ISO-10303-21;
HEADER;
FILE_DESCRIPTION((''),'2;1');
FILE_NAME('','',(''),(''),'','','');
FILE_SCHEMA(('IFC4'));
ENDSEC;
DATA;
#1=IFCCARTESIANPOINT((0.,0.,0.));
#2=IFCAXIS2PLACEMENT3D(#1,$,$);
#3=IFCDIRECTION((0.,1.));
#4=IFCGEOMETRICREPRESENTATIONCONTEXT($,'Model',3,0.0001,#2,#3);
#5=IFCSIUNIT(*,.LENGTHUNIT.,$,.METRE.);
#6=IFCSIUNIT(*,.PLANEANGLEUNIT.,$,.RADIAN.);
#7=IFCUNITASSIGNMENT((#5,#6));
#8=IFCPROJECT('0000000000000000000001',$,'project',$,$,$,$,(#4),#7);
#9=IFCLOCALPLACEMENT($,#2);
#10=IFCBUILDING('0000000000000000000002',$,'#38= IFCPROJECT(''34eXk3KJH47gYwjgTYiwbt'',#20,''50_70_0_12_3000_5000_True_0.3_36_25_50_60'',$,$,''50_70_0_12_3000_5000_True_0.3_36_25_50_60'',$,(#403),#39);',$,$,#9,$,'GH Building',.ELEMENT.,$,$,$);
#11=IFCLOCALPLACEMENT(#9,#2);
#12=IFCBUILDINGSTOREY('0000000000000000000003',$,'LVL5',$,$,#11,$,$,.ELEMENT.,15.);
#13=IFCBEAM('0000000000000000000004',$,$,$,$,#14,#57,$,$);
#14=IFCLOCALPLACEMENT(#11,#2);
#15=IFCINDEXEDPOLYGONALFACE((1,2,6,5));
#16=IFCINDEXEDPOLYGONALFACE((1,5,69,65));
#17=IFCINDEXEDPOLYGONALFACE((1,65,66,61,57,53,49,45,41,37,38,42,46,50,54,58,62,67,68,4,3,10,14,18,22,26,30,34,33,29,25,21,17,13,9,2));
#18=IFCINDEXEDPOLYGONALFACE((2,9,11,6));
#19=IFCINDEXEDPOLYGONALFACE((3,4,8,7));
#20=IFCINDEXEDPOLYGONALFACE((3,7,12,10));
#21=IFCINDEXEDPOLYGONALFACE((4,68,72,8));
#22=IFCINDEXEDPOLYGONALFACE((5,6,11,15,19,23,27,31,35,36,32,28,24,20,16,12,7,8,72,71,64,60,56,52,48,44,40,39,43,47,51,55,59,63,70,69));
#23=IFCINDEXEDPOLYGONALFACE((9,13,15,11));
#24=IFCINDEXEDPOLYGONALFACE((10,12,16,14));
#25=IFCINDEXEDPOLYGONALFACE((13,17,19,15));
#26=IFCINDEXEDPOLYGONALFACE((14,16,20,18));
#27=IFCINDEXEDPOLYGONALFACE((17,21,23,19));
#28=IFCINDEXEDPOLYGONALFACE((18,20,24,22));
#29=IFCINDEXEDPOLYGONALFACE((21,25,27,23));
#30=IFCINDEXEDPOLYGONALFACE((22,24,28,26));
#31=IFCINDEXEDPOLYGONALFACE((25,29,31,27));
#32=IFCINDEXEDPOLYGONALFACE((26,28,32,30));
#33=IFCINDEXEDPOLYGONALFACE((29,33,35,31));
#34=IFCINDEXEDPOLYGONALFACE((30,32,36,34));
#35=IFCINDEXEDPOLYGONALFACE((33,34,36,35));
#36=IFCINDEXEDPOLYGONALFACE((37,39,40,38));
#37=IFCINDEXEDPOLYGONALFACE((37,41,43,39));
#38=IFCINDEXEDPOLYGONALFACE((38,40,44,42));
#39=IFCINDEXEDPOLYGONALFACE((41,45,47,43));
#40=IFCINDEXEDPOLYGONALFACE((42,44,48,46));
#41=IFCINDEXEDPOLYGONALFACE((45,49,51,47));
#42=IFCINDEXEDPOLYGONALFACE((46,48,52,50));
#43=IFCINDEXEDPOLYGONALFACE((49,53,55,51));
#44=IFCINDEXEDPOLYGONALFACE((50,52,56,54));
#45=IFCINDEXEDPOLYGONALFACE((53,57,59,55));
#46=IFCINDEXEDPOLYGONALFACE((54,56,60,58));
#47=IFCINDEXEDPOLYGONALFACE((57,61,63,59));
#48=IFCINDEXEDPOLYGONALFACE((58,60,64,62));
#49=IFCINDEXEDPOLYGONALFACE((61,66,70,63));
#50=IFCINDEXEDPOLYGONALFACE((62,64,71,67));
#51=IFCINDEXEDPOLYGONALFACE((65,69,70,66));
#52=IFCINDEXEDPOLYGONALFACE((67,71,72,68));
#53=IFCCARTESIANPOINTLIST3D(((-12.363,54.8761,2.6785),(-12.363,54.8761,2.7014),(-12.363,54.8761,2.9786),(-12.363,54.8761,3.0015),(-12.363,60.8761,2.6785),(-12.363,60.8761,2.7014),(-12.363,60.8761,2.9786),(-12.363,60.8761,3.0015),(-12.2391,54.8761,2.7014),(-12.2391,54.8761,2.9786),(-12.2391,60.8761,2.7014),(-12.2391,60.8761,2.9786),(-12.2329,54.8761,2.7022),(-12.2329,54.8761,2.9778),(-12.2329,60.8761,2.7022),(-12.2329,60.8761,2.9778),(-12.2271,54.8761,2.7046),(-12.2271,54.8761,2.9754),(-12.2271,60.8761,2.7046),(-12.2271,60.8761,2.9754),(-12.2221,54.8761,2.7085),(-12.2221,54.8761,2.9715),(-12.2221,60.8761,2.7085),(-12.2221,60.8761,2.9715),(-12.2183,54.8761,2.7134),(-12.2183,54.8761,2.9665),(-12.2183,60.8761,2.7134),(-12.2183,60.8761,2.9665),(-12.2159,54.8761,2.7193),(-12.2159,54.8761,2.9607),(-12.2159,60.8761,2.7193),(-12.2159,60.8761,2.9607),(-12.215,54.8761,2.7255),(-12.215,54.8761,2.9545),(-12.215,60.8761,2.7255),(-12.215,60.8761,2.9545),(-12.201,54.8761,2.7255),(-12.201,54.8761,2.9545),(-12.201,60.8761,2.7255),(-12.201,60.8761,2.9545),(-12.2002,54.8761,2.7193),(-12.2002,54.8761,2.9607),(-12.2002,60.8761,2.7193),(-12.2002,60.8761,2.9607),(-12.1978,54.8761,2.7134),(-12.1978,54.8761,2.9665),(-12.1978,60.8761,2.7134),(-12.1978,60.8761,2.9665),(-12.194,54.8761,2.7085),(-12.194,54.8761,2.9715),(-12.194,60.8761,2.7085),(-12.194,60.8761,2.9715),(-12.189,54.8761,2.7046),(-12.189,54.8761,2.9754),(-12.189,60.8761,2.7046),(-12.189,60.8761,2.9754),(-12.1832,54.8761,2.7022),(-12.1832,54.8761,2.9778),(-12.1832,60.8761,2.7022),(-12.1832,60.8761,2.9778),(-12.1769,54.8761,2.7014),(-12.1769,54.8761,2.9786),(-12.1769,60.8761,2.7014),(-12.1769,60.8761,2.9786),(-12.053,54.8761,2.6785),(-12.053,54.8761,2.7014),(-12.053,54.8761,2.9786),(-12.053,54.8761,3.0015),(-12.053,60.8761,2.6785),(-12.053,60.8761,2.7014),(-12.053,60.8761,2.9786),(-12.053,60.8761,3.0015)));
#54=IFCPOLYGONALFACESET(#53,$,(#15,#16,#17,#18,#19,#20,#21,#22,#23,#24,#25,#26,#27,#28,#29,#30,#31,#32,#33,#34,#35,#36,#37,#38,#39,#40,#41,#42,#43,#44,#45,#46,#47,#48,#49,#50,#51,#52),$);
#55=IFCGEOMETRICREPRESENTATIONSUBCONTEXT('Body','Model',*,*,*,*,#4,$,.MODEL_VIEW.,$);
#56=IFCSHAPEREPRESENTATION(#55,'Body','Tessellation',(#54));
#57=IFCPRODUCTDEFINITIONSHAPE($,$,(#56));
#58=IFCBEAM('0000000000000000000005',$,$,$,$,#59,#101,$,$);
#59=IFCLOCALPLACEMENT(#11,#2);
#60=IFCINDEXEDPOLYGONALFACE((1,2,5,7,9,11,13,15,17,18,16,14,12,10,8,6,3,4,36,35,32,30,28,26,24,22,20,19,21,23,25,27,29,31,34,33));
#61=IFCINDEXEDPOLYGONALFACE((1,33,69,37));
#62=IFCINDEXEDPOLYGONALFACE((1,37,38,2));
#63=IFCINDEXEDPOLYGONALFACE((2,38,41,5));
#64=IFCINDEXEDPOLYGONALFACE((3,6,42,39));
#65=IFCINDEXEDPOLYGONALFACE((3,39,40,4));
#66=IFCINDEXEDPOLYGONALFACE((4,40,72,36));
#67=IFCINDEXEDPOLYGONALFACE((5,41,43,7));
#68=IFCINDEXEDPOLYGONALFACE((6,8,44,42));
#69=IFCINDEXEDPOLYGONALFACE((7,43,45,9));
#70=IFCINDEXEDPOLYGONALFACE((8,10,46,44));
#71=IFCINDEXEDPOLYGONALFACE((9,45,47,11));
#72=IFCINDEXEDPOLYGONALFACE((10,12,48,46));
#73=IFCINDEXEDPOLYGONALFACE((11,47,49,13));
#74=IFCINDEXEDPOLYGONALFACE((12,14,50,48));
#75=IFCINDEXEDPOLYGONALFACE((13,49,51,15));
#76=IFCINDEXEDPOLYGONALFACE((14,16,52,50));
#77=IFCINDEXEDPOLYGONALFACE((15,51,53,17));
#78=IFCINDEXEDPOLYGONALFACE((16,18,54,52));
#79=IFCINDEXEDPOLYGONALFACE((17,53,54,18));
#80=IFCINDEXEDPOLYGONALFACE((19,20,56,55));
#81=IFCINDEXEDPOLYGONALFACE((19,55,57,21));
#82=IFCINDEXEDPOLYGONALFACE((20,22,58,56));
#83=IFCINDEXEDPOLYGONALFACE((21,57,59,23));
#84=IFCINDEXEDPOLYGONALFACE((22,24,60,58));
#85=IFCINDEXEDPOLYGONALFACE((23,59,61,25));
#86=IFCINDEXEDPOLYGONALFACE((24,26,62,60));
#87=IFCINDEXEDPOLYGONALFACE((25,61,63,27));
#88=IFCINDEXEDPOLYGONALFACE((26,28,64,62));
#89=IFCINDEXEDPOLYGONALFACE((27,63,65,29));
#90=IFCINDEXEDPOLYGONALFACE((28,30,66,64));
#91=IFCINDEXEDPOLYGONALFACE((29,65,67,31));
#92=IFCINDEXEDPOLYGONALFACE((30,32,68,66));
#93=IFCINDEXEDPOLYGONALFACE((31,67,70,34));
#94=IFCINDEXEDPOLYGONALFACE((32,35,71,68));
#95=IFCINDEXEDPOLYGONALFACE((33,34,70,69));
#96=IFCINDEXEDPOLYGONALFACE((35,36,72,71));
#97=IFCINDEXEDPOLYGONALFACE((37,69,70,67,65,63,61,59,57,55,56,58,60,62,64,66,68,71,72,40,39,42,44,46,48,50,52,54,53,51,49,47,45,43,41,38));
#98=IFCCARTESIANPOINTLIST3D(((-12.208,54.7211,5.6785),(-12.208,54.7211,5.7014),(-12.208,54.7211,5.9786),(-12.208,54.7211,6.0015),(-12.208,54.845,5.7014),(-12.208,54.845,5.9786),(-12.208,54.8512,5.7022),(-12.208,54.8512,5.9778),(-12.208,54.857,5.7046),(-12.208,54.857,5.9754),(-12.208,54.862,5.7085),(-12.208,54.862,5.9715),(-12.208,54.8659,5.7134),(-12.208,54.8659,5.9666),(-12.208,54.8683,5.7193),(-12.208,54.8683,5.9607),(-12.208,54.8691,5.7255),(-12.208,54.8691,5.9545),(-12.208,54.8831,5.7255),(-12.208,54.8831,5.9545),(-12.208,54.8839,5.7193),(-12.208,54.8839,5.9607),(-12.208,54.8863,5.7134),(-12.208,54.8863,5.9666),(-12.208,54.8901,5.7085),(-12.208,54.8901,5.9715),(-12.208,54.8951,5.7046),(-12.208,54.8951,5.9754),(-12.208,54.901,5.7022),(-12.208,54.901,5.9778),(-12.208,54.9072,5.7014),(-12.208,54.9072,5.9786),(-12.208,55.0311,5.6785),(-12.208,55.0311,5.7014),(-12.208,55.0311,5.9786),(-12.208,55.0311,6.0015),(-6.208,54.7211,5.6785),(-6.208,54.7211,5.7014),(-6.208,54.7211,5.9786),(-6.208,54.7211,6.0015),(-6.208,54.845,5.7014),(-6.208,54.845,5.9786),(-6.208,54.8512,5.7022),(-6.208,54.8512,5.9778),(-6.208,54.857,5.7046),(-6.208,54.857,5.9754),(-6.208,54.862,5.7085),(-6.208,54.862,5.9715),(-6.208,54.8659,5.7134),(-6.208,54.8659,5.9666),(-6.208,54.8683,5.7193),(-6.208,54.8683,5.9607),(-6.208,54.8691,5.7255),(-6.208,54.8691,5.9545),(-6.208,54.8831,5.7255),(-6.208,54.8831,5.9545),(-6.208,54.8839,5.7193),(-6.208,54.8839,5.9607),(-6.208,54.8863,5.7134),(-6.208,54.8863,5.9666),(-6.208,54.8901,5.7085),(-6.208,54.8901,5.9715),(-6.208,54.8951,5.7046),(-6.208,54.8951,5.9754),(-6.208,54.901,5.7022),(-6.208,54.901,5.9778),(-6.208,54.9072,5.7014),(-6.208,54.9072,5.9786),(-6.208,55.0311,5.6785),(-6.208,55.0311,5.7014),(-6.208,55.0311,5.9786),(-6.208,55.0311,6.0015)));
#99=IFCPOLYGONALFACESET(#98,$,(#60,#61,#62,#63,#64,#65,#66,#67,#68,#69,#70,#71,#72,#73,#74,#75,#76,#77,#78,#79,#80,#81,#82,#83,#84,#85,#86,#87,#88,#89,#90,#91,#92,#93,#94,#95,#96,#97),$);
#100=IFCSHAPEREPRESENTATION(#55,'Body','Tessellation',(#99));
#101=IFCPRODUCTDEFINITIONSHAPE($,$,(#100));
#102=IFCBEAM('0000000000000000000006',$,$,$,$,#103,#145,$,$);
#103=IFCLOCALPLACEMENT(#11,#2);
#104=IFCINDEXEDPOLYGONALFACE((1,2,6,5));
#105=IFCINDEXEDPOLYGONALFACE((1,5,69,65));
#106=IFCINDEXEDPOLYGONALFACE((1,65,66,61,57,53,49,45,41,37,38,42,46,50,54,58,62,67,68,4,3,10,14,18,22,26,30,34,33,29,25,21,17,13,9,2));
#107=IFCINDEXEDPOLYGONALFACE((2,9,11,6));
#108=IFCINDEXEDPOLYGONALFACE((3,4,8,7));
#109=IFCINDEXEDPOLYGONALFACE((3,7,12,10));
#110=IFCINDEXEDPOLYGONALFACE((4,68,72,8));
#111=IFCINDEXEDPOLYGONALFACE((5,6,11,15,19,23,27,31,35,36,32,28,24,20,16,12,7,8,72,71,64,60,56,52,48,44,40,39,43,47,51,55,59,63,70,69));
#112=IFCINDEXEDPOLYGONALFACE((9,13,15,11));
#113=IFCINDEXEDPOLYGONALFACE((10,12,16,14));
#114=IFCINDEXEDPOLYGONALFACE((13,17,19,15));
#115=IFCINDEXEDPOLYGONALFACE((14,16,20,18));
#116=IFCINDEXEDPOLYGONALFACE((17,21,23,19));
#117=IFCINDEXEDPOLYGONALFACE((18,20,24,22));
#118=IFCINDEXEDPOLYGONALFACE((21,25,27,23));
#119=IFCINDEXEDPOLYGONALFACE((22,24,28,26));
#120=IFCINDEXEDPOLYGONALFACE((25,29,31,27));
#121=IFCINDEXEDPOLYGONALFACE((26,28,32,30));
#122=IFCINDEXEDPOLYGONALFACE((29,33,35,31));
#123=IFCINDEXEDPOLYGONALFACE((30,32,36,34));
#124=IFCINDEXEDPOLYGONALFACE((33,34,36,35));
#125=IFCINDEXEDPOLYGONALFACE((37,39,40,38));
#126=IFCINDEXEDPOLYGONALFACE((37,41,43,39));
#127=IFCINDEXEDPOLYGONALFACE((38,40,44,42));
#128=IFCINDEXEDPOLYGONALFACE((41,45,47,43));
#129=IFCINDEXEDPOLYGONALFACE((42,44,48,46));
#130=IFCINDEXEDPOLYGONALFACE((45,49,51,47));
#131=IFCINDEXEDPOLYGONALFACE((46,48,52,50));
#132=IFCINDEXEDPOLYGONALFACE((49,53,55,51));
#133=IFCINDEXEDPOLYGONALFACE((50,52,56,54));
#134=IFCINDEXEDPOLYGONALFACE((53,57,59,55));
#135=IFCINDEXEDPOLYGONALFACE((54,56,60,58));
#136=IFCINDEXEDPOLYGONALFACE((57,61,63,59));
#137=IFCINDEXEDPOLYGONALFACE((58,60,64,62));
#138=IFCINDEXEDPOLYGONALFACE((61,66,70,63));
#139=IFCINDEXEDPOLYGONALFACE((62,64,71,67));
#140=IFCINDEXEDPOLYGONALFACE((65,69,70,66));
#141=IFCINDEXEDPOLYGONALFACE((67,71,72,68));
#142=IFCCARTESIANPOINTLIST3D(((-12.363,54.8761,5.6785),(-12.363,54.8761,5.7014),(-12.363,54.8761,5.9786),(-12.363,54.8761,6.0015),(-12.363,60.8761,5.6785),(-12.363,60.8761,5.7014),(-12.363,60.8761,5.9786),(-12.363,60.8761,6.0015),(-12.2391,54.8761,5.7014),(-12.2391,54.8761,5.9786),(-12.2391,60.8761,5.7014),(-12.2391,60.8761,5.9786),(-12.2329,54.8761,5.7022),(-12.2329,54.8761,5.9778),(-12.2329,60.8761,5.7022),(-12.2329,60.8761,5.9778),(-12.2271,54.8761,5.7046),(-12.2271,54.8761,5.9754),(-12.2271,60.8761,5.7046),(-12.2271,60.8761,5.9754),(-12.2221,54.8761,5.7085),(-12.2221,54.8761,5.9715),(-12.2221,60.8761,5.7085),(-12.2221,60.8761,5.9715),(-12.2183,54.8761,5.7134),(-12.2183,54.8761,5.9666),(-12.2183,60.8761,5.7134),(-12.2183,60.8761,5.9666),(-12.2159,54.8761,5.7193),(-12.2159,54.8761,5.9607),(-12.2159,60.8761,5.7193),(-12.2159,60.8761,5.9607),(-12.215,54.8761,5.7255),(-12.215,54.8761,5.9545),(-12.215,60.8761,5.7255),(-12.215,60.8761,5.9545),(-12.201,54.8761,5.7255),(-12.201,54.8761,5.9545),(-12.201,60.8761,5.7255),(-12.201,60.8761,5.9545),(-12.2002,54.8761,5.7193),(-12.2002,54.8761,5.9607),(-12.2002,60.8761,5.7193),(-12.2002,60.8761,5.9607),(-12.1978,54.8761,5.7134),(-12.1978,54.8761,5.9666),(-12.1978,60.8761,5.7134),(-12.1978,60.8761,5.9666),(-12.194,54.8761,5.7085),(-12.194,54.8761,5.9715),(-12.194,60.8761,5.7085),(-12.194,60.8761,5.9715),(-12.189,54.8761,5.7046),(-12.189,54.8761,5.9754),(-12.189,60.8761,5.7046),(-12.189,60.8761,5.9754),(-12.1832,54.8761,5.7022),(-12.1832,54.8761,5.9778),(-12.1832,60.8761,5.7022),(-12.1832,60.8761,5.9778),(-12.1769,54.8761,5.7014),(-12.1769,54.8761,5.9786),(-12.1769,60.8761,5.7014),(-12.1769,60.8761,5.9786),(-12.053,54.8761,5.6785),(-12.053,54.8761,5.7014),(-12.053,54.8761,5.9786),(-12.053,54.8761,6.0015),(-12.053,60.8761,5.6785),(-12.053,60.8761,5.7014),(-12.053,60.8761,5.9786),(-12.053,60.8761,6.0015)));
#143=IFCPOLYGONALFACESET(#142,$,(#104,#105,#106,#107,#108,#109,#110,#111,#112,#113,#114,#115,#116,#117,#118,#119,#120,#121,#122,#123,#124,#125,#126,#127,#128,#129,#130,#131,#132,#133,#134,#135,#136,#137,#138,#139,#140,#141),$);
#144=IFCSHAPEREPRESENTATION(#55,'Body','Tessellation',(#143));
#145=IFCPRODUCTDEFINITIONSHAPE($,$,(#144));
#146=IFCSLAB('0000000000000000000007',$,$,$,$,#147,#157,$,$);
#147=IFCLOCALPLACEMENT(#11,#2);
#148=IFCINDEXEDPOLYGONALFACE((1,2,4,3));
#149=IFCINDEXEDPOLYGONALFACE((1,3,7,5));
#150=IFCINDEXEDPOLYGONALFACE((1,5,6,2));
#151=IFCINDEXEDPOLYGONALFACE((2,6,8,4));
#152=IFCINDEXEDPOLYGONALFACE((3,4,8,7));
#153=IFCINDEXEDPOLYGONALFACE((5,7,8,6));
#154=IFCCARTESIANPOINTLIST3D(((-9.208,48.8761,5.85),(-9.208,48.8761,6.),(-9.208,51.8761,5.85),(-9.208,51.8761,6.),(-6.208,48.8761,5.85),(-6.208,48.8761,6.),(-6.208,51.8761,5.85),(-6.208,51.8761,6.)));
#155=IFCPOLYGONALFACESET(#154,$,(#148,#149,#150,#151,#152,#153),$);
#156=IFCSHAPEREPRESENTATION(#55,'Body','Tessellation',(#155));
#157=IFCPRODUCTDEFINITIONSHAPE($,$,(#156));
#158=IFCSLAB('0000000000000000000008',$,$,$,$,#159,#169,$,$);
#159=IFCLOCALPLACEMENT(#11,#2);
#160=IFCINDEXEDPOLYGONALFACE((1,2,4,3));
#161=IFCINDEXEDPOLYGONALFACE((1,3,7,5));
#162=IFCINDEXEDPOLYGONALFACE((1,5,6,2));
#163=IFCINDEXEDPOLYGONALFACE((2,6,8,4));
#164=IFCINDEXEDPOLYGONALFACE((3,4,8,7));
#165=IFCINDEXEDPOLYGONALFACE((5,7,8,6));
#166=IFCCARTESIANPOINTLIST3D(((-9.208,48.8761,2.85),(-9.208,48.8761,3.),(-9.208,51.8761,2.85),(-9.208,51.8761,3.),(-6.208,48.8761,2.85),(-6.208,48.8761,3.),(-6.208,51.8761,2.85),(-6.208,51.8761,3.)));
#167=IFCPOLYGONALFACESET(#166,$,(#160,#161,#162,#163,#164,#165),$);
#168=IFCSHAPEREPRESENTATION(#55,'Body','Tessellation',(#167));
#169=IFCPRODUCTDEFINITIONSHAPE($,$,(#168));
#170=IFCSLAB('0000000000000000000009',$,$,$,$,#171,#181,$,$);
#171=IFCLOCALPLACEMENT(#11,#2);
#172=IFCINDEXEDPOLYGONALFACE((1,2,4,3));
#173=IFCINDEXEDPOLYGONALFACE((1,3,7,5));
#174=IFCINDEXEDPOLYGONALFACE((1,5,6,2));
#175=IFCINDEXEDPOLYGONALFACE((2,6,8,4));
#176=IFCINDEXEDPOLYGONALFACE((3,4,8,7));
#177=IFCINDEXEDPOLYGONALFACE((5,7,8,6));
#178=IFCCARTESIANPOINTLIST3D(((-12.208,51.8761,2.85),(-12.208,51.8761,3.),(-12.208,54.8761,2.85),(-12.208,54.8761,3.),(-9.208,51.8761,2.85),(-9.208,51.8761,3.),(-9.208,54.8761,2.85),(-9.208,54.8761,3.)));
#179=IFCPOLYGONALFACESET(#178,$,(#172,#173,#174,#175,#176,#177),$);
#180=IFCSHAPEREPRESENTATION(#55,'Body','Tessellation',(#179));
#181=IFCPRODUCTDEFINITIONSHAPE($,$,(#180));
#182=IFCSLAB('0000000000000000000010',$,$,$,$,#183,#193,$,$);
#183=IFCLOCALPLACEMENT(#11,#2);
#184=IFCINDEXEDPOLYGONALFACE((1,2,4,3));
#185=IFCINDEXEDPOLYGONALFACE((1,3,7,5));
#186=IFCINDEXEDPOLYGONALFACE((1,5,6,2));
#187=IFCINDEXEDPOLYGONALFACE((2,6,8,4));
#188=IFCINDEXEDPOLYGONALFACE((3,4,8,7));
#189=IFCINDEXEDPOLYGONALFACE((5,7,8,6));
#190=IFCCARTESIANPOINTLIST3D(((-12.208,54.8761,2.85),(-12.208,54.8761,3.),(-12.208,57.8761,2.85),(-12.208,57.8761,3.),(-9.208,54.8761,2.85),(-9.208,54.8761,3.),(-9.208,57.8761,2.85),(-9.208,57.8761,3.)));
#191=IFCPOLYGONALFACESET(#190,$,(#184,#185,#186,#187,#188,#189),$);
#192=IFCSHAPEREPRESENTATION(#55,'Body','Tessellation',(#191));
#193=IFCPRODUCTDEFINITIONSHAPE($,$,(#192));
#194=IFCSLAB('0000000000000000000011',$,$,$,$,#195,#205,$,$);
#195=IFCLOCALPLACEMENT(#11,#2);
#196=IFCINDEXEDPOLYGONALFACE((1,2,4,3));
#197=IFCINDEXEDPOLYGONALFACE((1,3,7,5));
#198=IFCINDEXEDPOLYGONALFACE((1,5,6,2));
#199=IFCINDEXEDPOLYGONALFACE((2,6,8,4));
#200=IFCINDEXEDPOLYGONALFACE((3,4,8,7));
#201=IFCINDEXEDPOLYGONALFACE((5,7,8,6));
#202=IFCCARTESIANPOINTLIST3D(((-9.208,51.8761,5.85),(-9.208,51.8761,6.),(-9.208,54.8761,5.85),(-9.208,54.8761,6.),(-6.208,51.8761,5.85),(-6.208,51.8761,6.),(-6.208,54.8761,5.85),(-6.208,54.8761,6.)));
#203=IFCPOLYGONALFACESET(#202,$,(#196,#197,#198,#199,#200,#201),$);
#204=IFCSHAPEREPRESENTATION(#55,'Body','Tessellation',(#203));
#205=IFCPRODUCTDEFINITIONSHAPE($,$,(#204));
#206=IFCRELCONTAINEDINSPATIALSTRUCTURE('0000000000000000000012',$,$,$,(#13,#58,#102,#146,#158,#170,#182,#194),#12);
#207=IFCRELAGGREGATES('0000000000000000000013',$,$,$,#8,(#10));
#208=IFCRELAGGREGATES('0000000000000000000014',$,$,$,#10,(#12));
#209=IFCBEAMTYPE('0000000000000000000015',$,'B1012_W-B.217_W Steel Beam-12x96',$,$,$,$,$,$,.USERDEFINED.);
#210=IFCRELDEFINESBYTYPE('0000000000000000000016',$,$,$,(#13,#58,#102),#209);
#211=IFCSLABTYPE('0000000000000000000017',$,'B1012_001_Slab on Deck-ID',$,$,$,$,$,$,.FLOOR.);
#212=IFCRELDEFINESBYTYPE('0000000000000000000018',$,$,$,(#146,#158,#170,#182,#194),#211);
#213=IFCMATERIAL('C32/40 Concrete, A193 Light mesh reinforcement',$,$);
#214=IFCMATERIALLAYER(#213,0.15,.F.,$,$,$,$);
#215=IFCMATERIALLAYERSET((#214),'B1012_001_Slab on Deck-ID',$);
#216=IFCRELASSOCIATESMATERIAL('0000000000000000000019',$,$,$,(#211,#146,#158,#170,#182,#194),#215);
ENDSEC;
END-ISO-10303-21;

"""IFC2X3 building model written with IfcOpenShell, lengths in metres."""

from ifc_helpers import new_model, si_unit, direction, frame, origin, origin_2d, place, context, subcontext, project, spatial, polyline, i_section, outline, extrude, material, layer, layer_set, layer_usage, type_object, element, save


model = new_model("IFC2X3")

# Units and contexts
model_context = context("Model", 3, precision=0.0001, world=origin(), true_north=direction((0.0, 1.0)))
body_context = subcontext(model_context, "Body", "Model", "MODEL_VIEW")
ifc_project = project(units=[si_unit("LENGTHUNIT", "METRE"), si_unit("PLANEANGLEUNIT", "RADIAN")], contexts=[model_context])

# Building, storey
building_placement = place(None, origin())
building = spatial("IfcBuilding", under=ifc_project, at=building_placement, Name="#38= IFCPROJECT('34eXk3KJH47gYwjgTYiwbt',#20,'50_70_0_12_3000_5000_True_0.3_36_25_50_60',$,$,'50_70_0_12_3000_5000_True_0.3_36_25_50_60',$,(#403),#39);", LongName="GH Building", CompositionType="ELEMENT")
storey_placement = place(building_placement, origin())
storey = spatial("IfcBuildingStorey", under=building, at=storey_placement, Name="LVL5", CompositionType="ELEMENT", Elevation=15.0)

# Beams
beam_type = type_object("IfcBeamType", Name="B1012_W-B.217_W Steel Beam-12x96", PredefinedType="USERDEFINED")
for number, where, z_axis, x_axis in (
    (1, (-12.208, 54.8761, 2.84), (0.0, 1.0, 0.0), (-1.0, 0.0, 0.0)),
    (2, (-12.208, 54.8761, 5.84), (1.0, 0.0, 0.0), (0.0, 1.0, 0.0)),
    (3, (-12.208, 54.8761, 5.84), (0.0, 1.0, 0.0), (-1.0, 0.0, 0.0)),
):
    element("IfcBeam", number, at=place(storey_placement, frame(where, z_axis=z_axis, x_axis=x_axis)), inside=storey, type_object=beam_type, context=body_context, shape_type="SweptSolid", body=[
        extrude(i_section(OverallWidth=0.31, OverallDepth=0.323, WebThickness=0.014, FlangeThickness=0.0229, FilletRadius=0.0241, at=origin_2d()), origin(), (0.0, 0.0, 1.0), 6.0),
    ])

# Slabs
ifc_material_1 = material(Name="C32/40 Concrete, A193 Light mesh reinforcement")
ifc_layer_1 = layer(ifc_material_1, 0.15, ventilated=False)
ifc_layer_set_1 = layer_set([ifc_layer_1], Name="B1012_001_Slab on Deck-ID")
ifc_layer_usage_1 = layer_usage(ifc_layer_set_1, "AXIS3", "NEGATIVE", -0.15)
slab_type_1 = type_object("IfcSlabType", Name="B1012_001_Slab on Deck-ID", PredefinedType="FLOOR", material=ifc_layer_set_1)
slab_1_placement = place(storey_placement, frame((-7.708, 50.3761, 5.85)))
element("IfcSlab", 4, at=slab_1_placement, inside=storey, type_object=slab_type_1, material=ifc_layer_usage_1, context=body_context, shape_type="SweptSolid", body=[
    extrude(outline(polyline([(1.5, -1.5), (-1.5, -1.5), (-1.5, 1.5), (1.5, 1.5), (1.5, -1.5)])), origin(), (0.0, 0.0, 1.0), 0.15),
])
ifc_layer_usage_2 = layer_usage(ifc_layer_set_1, "AXIS3", "NEGATIVE", -0.15)
slab_2_placement = place(storey_placement, frame((-7.708, 50.3761, 2.85), z_axis=(0.0, 0.0, 1.0), x_axis=(0.0, -1.0, 0.0)))
element("IfcSlab", 5, at=slab_2_placement, inside=storey, type_object=slab_type_1, material=ifc_layer_usage_2, context=body_context, shape_type="SweptSolid", body=[
    extrude(outline(polyline([(-1.5, -1.5), (1.5, -1.5), (1.5, 1.5), (-1.5, 1.5), (-1.5, -1.5)])), origin(), (0.0, 0.0, 1.0), 0.15),
])
ifc_layer_usage_3 = layer_usage(ifc_layer_set_1, "AXIS3", "NEGATIVE", -0.15)
slab_3_placement = place(storey_placement, frame((-10.708, 53.3761, 2.85), z_axis=(0.0, 0.0, 1.0), x_axis=(0.0, -1.0, 0.0)))
element("IfcSlab", 6, at=slab_3_placement, inside=storey, type_object=slab_type_1, material=ifc_layer_usage_3, context=body_context, shape_type="SweptSolid", body=[
    extrude(outline(polyline([(-1.5, -1.5), (1.5, -1.5), (1.5, 1.5), (-1.5, 1.5), (-1.5, -1.5)])), origin(), (0.0, 0.0, 1.0), 0.15),
])
ifc_layer_usage_4 = layer_usage(ifc_layer_set_1, "AXIS3", "NEGATIVE", -0.15)
slab_4_placement = place(storey_placement, frame((-10.708, 56.3761, 2.85), z_axis=(0.0, 0.0, 1.0), x_axis=(0.0, -1.0, 0.0)))
element("IfcSlab", 7, at=slab_4_placement, inside=storey, type_object=slab_type_1, material=ifc_layer_usage_4, context=body_context, shape_type="SweptSolid", body=[
    extrude(outline(polyline([(-1.5, -1.5), (1.5, -1.5), (1.5, 1.5), (-1.5, 1.5), (-1.5, -1.5)])), origin(), (0.0, 0.0, 1.0), 0.15),
])
ifc_layer_usage_5 = layer_usage(ifc_layer_set_1, "AXIS3", "NEGATIVE", -0.15)
slab_5_placement = place(storey_placement, frame((-7.708, 53.3761, 5.85)))
element("IfcSlab", 8, at=slab_5_placement, inside=storey, type_object=slab_type_1, material=ifc_layer_usage_5, context=body_context, shape_type="SweptSolid", body=[
    extrude(outline(polyline([(1.5, -1.5), (-1.5, -1.5), (-1.5, 1.5), (1.5, 1.5), (1.5, -1.5)])), origin(), (0.0, 0.0, 1.0), 0.15),
])

save(model, "model.ifc")
